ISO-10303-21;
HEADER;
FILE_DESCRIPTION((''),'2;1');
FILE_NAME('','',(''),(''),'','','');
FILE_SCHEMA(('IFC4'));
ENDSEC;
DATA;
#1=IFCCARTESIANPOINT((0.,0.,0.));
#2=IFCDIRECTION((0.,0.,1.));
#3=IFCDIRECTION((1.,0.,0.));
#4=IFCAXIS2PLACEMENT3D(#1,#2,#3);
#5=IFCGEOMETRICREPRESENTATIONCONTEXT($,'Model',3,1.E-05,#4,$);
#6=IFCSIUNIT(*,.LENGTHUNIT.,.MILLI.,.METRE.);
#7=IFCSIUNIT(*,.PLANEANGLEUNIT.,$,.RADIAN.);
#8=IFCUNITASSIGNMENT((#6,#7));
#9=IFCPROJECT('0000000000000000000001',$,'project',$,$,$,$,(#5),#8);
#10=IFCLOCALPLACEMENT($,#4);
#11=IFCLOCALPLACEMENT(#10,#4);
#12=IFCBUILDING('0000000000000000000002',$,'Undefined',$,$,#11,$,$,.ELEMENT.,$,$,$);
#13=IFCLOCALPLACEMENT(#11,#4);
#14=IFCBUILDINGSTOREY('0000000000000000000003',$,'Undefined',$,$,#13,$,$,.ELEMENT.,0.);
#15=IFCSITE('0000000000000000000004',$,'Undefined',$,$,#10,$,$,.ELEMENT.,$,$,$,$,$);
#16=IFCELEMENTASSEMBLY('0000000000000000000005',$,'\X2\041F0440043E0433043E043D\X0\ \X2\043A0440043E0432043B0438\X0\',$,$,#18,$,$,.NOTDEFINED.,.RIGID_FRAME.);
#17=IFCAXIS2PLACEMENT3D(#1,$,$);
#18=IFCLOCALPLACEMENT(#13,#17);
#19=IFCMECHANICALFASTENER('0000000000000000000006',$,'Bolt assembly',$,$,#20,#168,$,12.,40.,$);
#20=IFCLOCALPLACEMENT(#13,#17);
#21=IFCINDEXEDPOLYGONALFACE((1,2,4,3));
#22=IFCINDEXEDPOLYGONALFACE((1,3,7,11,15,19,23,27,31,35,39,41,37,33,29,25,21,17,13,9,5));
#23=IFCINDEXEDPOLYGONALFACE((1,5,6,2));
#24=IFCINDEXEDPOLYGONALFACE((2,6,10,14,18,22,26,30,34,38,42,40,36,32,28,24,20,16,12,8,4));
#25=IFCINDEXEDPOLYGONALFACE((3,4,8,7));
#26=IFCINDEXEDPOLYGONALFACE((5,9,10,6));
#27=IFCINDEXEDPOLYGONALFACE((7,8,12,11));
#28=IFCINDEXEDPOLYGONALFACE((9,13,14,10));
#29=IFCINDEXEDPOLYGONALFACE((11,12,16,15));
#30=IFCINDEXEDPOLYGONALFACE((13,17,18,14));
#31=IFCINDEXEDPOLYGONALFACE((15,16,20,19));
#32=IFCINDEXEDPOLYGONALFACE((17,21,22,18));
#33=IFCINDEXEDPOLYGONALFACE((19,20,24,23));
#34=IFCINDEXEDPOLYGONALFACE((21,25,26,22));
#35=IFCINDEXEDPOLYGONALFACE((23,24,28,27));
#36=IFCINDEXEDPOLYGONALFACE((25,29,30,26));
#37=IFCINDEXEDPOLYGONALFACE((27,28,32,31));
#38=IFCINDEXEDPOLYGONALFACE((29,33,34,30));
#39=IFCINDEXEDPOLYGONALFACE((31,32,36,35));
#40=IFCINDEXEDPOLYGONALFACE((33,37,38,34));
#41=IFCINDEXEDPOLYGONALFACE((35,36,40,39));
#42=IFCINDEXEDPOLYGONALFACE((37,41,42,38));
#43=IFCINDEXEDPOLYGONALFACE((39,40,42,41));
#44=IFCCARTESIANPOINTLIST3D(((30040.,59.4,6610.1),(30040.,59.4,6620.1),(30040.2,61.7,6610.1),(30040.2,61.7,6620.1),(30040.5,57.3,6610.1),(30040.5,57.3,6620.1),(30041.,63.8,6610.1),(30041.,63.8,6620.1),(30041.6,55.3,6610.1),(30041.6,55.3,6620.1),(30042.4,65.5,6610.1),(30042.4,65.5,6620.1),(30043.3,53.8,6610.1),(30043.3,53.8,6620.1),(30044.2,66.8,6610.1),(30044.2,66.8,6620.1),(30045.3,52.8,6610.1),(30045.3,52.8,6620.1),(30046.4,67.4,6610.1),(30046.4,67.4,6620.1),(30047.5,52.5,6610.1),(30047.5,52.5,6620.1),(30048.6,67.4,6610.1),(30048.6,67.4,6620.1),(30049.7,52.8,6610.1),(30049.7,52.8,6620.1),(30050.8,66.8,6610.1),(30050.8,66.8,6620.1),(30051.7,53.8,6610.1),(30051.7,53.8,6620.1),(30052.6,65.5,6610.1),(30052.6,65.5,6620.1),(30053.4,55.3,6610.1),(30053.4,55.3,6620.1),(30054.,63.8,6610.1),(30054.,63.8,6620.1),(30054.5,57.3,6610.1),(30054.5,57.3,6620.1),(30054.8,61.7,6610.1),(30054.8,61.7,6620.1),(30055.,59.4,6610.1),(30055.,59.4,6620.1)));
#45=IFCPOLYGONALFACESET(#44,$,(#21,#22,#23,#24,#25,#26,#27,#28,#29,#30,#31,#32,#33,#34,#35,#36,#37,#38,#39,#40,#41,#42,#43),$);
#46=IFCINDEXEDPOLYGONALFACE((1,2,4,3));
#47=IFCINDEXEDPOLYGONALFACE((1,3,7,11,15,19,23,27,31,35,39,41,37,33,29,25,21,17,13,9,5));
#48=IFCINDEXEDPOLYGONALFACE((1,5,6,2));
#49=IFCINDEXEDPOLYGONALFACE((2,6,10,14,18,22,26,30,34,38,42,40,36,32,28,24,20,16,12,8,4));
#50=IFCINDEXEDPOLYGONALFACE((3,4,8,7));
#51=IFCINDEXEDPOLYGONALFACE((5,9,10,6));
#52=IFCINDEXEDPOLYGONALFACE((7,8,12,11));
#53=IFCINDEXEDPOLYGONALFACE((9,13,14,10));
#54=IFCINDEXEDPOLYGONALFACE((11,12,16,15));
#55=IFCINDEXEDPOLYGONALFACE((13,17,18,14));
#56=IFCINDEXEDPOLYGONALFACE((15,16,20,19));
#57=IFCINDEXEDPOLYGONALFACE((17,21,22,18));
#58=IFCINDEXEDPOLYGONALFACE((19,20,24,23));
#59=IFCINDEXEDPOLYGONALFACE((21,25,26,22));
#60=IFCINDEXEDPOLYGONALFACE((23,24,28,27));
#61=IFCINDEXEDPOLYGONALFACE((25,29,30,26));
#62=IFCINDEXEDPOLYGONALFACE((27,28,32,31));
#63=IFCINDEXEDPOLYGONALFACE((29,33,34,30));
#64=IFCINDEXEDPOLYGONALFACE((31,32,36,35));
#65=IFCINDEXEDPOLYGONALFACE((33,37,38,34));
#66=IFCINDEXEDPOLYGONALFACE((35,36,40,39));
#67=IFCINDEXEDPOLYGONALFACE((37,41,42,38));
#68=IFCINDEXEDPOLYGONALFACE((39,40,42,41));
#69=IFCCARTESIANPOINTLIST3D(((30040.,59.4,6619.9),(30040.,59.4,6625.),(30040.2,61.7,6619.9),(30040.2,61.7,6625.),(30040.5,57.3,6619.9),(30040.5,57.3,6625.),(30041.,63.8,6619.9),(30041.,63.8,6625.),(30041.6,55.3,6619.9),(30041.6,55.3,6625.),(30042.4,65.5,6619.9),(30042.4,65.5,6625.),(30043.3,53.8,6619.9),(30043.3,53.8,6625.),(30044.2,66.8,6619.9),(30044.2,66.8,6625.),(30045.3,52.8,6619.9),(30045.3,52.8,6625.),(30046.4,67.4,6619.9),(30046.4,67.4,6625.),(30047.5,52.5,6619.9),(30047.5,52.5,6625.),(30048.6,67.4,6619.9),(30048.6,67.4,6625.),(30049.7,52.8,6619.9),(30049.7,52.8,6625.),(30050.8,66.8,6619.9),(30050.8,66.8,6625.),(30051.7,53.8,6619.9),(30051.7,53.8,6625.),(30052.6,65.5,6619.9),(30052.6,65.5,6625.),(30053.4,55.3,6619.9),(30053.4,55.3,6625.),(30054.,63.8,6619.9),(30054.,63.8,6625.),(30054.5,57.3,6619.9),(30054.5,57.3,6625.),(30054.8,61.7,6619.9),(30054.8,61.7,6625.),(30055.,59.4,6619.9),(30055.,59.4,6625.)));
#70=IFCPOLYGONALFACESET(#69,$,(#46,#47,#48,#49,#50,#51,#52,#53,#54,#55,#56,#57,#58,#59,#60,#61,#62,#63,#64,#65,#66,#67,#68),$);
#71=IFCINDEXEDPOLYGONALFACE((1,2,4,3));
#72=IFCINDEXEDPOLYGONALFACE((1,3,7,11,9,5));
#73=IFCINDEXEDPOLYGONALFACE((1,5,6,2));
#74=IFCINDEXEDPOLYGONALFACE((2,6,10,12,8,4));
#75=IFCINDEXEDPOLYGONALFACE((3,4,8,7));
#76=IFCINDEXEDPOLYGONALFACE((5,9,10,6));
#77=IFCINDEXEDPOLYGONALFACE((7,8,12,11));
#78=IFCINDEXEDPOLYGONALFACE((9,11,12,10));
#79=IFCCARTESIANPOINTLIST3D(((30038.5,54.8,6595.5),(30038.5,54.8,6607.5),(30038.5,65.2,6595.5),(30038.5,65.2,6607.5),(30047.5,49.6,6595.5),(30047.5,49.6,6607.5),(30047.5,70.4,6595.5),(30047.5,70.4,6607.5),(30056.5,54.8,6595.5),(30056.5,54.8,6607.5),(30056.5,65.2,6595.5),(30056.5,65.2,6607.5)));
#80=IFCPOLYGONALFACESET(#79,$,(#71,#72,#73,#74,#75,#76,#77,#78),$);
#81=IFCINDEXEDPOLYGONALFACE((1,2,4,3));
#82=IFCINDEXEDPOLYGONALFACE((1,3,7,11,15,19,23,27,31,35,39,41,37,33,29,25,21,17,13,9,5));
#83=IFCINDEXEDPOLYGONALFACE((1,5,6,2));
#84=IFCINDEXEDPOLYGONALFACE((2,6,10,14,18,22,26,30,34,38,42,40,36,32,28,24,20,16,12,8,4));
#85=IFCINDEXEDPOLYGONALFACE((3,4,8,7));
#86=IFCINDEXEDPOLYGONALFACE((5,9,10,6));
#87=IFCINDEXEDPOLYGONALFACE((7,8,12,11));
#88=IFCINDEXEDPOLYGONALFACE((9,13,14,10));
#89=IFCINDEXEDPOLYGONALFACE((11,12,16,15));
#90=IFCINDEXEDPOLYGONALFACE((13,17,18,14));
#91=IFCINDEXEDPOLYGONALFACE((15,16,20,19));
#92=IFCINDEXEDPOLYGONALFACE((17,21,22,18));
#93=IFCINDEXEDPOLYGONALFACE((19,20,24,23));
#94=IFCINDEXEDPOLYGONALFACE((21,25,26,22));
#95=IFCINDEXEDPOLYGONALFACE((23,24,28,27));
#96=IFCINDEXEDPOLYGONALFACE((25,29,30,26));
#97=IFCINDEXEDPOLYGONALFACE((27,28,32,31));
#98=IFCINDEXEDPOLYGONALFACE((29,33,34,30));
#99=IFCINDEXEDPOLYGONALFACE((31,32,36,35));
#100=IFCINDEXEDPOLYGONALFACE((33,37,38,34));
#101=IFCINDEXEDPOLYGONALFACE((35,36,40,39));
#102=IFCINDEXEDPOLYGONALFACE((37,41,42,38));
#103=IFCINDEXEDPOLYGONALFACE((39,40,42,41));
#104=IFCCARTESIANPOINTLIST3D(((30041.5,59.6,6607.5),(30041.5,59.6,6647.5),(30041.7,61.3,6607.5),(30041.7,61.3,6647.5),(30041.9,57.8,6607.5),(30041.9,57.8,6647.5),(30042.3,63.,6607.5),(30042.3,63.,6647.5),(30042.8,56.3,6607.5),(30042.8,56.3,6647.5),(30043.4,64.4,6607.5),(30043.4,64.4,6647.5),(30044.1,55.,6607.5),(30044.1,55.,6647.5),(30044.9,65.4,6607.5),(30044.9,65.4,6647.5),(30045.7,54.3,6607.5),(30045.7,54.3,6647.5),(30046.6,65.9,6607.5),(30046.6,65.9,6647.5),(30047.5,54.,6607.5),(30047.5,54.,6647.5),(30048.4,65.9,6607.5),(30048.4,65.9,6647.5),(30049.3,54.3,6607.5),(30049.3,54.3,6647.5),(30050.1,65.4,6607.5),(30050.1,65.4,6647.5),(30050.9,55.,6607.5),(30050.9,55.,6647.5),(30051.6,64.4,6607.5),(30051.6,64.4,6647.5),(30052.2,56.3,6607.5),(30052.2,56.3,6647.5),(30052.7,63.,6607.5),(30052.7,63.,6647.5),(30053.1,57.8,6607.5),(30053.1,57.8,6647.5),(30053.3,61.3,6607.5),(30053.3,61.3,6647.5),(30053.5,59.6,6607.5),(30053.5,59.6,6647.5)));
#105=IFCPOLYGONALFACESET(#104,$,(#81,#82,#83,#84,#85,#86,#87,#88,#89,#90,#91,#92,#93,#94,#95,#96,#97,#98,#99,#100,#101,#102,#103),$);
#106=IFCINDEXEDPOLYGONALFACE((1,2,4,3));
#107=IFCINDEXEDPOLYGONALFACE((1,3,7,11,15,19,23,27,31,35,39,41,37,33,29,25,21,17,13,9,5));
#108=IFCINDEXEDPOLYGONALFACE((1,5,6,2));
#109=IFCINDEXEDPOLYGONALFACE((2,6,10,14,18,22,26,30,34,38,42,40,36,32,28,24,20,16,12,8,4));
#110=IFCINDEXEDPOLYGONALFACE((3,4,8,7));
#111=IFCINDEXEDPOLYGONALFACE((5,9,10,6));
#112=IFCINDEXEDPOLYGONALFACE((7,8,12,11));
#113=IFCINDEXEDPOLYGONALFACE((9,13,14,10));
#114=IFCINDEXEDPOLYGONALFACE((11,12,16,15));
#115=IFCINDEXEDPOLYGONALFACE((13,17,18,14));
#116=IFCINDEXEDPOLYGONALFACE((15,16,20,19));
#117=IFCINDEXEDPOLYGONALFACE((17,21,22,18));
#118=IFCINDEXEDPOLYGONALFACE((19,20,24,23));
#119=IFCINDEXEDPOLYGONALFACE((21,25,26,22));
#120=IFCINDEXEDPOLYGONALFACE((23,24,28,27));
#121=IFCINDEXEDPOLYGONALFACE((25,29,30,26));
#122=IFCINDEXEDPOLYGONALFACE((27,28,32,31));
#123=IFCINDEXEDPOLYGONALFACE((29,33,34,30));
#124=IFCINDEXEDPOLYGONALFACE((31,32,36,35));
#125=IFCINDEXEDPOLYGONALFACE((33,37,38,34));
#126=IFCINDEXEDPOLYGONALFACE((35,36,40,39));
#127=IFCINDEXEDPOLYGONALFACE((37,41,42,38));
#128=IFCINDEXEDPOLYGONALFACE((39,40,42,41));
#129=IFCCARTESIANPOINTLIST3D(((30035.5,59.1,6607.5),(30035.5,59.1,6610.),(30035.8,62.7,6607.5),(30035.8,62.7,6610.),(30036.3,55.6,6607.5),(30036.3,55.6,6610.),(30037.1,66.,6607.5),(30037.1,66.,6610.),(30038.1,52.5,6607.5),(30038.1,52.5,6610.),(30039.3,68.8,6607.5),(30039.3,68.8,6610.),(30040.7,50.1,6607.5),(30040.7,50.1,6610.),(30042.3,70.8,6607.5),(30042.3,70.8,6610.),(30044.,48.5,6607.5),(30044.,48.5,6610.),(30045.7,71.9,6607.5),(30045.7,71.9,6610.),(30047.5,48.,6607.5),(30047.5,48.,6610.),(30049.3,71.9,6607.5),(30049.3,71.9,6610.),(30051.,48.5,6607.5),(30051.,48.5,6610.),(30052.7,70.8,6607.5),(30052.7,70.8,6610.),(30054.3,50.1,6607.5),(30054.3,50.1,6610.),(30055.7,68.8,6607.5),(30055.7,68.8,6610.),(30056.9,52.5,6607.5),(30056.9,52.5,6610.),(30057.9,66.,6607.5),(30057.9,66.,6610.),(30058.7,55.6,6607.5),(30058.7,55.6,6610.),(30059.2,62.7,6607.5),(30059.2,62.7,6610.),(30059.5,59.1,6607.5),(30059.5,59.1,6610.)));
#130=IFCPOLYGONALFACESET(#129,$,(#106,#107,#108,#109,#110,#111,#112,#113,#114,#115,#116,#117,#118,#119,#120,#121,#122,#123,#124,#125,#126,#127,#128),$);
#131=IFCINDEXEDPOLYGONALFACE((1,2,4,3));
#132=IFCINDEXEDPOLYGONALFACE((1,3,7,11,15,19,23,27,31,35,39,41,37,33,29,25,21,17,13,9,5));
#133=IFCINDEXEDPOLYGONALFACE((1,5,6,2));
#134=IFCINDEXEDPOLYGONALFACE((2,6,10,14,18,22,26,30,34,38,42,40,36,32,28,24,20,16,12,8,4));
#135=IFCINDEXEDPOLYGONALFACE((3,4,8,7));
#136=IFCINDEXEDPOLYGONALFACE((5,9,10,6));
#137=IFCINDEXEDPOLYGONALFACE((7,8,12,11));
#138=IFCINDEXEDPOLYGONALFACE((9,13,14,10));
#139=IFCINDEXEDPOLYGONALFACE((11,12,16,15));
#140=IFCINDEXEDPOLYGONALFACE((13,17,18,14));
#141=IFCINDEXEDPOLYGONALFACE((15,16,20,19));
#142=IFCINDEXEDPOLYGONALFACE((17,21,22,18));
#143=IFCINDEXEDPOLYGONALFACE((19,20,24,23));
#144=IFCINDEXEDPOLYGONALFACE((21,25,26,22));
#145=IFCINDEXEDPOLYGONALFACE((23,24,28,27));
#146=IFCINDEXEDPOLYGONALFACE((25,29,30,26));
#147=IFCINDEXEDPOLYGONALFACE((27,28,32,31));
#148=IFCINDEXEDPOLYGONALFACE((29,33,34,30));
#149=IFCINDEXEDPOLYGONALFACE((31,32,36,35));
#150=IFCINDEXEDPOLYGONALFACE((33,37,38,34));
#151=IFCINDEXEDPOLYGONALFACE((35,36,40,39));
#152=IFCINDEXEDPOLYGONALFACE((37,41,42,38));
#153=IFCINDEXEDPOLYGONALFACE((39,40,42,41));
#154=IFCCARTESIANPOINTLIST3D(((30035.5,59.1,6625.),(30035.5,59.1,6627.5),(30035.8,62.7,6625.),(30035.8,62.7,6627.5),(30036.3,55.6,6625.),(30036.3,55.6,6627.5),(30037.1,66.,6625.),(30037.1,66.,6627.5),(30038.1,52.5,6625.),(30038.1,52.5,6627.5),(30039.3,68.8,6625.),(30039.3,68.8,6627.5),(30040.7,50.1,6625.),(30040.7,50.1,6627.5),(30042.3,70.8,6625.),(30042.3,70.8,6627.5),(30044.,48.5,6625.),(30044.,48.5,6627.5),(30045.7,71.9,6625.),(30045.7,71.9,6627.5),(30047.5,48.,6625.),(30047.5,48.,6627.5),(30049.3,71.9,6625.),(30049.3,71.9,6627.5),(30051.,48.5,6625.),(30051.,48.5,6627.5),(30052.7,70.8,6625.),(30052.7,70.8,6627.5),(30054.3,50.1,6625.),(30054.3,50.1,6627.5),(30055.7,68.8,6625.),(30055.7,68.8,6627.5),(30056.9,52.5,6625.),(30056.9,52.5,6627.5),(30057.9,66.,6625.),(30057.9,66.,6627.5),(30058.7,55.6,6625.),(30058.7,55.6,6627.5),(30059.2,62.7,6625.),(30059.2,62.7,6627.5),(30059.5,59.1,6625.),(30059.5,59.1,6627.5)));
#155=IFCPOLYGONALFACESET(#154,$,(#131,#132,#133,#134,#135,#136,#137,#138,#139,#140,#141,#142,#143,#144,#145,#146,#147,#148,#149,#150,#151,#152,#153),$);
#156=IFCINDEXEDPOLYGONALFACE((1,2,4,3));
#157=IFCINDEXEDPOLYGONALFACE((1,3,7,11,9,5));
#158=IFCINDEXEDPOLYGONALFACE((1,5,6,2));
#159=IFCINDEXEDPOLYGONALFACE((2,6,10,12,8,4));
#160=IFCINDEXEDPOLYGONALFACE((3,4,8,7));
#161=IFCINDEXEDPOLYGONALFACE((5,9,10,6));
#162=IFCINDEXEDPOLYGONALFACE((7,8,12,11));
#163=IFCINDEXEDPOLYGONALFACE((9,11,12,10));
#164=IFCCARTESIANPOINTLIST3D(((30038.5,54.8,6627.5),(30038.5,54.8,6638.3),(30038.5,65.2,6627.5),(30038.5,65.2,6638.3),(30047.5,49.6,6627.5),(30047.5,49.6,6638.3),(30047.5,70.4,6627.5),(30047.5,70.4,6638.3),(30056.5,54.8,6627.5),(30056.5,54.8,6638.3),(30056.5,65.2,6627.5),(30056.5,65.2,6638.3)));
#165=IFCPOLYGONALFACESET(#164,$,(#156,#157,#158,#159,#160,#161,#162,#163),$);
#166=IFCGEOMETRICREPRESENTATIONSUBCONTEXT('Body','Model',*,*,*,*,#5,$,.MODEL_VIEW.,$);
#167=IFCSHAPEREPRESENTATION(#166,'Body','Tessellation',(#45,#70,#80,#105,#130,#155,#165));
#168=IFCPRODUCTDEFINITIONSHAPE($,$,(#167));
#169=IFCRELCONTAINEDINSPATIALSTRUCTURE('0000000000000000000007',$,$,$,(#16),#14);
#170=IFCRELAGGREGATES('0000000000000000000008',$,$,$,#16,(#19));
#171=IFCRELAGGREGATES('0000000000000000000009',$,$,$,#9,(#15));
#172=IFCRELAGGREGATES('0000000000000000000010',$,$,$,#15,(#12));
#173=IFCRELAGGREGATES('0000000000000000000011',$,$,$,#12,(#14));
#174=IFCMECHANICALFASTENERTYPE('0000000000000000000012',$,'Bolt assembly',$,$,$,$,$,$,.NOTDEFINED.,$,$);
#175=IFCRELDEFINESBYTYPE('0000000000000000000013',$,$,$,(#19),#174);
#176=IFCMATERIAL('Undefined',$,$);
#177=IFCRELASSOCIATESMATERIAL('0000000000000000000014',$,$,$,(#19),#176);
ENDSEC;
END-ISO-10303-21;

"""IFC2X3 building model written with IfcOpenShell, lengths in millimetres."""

from ifc_helpers import new_model, si_unit, frame, origin_with_axes, origin_2d_with_axis, place, context, subcontext, project, spatial, polyline, circle, outline, extrude, source, transform, mapped, material, type_object, element, aggregate, save


model = new_model("IFC2X3")

# Units and contexts
model_context = context("Model", 3, precision=1e-05, world=origin_with_axes())
body_context = subcontext(model_context, "Body", "Model", "MODEL_VIEW")
ifc_project = project(units=[si_unit("LENGTHUNIT", "METRE", prefix="MILLI"), si_unit("PLANEANGLEUNIT", "RADIAN")], contexts=[model_context])

# Site, building, storey
site_placement = place(None, origin_with_axes())
site = spatial("IfcSite", under=ifc_project, at=site_placement, Name="Undefined", CompositionType="ELEMENT")
building_placement = place(site_placement, origin_with_axes())
building = spatial("IfcBuilding", under=site, at=building_placement, Name="Undefined", CompositionType="ELEMENT")
storey_placement = place(building_placement, origin_with_axes())
storey = spatial("IfcBuildingStorey", under=building, at=storey_placement, Name="Undefined", CompositionType="ELEMENT", Elevation=0.0)

# Element assembly
assembly_1_placement = place(storey_placement, origin_with_axes())
assembly_1 = element("IfcElementAssembly", 1, at=assembly_1_placement, inside=storey, Name="Прогон кровли", AssemblyPlace="NOTDEFINED", PredefinedType="RIGID_FRAME")

# Mechanical fastener
ifc_material_1 = material(Name="Undefined")
mechanical_fastener_type = type_object("IfcMechanicalFastenerType", Name="Bolt assembly")
shared_shape_1 = source(origin_with_axes(), body_context, "Body", "SweptSolid", [
    extrude(circle(Radius=7.5, at=origin_2d_with_axis()), frame((0.0, -9.9, 0.0), z_axis=(0.0, 1.0, 0.0), x_axis=(1.0, 0.0, 0.0)), (0.0, 0.0, 1.0), 10.0),
    extrude(circle(Radius=7.5, at=origin_2d_with_axis()), frame((0.0, -0.1, 0.0), z_axis=(0.0, 1.0, 0.0), x_axis=(1.0, 0.0, 0.0)), (0.0, 0.0, 1.0), 5.1),
    extrude(outline(polyline([(10.4, 0.0), (5.2, 9.0), (-5.2, 9.0), (-10.4, 0.0), (-5.2, -9.0), (5.2, -9.0), (10.4, 0.0)])), frame((0.0, -24.5, 0.0), z_axis=(0.0, 1.0, 0.0), x_axis=(1.0, 0.0, 0.0)), (0.0, 0.0, 1.0), 12.0),
    extrude(circle(Radius=6.0, at=origin_2d_with_axis()), frame((0.0, -12.5, 0.0), z_axis=(0.0, 1.0, 0.0), x_axis=(1.0, 0.0, 0.0)), (0.0, 0.0, 1.0), 40.0),
    extrude(circle(Radius=12.0, at=origin_2d_with_axis()), frame((0.0, -12.5, 0.0), z_axis=(0.0, 1.0, 0.0), x_axis=(1.0, 0.0, 0.0)), (0.0, 0.0, 1.0), 2.5),
    extrude(circle(Radius=12.0, at=origin_2d_with_axis()), frame((0.0, 5.0, 0.0), z_axis=(0.0, 1.0, 0.0), x_axis=(1.0, 0.0, 0.0)), (0.0, 0.0, 1.0), 2.5),
    extrude(outline(polyline([(10.4, 0.0), (5.2, 9.0), (-5.2, 9.0), (-10.4, 0.0), (-5.2, -9.0), (5.2, -9.0), (10.4, 0.0)])), frame((0.0, 7.5, 0.0), z_axis=(0.0, 1.0, 0.0), x_axis=(1.0, 0.0, 0.0)), (0.0, 0.0, 1.0), 10.8),
])
mechanical_fastener_1_placement = place(assembly_1_placement, frame((30047.5, 60.0, 6620.0), z_axis=(-1.0, 0.0, 0.0), x_axis=(0.0, -1.0, 0.0)))
mechanical_fastener_1 = element("IfcMechanicalFastener", 2, at=mechanical_fastener_1_placement, type_object=mechanical_fastener_type, material=ifc_material_1, Name="Bolt assembly", NominalDiameter=12.0, NominalLength=40.0, context=body_context, shape_type="MappedRepresentation", body=[
    mapped(shared_shape_1, transform((0.0, 0.0, 0.0))),
])
aggregate(assembly_1, [mechanical_fastener_1])

save(model, "model.ifc")
